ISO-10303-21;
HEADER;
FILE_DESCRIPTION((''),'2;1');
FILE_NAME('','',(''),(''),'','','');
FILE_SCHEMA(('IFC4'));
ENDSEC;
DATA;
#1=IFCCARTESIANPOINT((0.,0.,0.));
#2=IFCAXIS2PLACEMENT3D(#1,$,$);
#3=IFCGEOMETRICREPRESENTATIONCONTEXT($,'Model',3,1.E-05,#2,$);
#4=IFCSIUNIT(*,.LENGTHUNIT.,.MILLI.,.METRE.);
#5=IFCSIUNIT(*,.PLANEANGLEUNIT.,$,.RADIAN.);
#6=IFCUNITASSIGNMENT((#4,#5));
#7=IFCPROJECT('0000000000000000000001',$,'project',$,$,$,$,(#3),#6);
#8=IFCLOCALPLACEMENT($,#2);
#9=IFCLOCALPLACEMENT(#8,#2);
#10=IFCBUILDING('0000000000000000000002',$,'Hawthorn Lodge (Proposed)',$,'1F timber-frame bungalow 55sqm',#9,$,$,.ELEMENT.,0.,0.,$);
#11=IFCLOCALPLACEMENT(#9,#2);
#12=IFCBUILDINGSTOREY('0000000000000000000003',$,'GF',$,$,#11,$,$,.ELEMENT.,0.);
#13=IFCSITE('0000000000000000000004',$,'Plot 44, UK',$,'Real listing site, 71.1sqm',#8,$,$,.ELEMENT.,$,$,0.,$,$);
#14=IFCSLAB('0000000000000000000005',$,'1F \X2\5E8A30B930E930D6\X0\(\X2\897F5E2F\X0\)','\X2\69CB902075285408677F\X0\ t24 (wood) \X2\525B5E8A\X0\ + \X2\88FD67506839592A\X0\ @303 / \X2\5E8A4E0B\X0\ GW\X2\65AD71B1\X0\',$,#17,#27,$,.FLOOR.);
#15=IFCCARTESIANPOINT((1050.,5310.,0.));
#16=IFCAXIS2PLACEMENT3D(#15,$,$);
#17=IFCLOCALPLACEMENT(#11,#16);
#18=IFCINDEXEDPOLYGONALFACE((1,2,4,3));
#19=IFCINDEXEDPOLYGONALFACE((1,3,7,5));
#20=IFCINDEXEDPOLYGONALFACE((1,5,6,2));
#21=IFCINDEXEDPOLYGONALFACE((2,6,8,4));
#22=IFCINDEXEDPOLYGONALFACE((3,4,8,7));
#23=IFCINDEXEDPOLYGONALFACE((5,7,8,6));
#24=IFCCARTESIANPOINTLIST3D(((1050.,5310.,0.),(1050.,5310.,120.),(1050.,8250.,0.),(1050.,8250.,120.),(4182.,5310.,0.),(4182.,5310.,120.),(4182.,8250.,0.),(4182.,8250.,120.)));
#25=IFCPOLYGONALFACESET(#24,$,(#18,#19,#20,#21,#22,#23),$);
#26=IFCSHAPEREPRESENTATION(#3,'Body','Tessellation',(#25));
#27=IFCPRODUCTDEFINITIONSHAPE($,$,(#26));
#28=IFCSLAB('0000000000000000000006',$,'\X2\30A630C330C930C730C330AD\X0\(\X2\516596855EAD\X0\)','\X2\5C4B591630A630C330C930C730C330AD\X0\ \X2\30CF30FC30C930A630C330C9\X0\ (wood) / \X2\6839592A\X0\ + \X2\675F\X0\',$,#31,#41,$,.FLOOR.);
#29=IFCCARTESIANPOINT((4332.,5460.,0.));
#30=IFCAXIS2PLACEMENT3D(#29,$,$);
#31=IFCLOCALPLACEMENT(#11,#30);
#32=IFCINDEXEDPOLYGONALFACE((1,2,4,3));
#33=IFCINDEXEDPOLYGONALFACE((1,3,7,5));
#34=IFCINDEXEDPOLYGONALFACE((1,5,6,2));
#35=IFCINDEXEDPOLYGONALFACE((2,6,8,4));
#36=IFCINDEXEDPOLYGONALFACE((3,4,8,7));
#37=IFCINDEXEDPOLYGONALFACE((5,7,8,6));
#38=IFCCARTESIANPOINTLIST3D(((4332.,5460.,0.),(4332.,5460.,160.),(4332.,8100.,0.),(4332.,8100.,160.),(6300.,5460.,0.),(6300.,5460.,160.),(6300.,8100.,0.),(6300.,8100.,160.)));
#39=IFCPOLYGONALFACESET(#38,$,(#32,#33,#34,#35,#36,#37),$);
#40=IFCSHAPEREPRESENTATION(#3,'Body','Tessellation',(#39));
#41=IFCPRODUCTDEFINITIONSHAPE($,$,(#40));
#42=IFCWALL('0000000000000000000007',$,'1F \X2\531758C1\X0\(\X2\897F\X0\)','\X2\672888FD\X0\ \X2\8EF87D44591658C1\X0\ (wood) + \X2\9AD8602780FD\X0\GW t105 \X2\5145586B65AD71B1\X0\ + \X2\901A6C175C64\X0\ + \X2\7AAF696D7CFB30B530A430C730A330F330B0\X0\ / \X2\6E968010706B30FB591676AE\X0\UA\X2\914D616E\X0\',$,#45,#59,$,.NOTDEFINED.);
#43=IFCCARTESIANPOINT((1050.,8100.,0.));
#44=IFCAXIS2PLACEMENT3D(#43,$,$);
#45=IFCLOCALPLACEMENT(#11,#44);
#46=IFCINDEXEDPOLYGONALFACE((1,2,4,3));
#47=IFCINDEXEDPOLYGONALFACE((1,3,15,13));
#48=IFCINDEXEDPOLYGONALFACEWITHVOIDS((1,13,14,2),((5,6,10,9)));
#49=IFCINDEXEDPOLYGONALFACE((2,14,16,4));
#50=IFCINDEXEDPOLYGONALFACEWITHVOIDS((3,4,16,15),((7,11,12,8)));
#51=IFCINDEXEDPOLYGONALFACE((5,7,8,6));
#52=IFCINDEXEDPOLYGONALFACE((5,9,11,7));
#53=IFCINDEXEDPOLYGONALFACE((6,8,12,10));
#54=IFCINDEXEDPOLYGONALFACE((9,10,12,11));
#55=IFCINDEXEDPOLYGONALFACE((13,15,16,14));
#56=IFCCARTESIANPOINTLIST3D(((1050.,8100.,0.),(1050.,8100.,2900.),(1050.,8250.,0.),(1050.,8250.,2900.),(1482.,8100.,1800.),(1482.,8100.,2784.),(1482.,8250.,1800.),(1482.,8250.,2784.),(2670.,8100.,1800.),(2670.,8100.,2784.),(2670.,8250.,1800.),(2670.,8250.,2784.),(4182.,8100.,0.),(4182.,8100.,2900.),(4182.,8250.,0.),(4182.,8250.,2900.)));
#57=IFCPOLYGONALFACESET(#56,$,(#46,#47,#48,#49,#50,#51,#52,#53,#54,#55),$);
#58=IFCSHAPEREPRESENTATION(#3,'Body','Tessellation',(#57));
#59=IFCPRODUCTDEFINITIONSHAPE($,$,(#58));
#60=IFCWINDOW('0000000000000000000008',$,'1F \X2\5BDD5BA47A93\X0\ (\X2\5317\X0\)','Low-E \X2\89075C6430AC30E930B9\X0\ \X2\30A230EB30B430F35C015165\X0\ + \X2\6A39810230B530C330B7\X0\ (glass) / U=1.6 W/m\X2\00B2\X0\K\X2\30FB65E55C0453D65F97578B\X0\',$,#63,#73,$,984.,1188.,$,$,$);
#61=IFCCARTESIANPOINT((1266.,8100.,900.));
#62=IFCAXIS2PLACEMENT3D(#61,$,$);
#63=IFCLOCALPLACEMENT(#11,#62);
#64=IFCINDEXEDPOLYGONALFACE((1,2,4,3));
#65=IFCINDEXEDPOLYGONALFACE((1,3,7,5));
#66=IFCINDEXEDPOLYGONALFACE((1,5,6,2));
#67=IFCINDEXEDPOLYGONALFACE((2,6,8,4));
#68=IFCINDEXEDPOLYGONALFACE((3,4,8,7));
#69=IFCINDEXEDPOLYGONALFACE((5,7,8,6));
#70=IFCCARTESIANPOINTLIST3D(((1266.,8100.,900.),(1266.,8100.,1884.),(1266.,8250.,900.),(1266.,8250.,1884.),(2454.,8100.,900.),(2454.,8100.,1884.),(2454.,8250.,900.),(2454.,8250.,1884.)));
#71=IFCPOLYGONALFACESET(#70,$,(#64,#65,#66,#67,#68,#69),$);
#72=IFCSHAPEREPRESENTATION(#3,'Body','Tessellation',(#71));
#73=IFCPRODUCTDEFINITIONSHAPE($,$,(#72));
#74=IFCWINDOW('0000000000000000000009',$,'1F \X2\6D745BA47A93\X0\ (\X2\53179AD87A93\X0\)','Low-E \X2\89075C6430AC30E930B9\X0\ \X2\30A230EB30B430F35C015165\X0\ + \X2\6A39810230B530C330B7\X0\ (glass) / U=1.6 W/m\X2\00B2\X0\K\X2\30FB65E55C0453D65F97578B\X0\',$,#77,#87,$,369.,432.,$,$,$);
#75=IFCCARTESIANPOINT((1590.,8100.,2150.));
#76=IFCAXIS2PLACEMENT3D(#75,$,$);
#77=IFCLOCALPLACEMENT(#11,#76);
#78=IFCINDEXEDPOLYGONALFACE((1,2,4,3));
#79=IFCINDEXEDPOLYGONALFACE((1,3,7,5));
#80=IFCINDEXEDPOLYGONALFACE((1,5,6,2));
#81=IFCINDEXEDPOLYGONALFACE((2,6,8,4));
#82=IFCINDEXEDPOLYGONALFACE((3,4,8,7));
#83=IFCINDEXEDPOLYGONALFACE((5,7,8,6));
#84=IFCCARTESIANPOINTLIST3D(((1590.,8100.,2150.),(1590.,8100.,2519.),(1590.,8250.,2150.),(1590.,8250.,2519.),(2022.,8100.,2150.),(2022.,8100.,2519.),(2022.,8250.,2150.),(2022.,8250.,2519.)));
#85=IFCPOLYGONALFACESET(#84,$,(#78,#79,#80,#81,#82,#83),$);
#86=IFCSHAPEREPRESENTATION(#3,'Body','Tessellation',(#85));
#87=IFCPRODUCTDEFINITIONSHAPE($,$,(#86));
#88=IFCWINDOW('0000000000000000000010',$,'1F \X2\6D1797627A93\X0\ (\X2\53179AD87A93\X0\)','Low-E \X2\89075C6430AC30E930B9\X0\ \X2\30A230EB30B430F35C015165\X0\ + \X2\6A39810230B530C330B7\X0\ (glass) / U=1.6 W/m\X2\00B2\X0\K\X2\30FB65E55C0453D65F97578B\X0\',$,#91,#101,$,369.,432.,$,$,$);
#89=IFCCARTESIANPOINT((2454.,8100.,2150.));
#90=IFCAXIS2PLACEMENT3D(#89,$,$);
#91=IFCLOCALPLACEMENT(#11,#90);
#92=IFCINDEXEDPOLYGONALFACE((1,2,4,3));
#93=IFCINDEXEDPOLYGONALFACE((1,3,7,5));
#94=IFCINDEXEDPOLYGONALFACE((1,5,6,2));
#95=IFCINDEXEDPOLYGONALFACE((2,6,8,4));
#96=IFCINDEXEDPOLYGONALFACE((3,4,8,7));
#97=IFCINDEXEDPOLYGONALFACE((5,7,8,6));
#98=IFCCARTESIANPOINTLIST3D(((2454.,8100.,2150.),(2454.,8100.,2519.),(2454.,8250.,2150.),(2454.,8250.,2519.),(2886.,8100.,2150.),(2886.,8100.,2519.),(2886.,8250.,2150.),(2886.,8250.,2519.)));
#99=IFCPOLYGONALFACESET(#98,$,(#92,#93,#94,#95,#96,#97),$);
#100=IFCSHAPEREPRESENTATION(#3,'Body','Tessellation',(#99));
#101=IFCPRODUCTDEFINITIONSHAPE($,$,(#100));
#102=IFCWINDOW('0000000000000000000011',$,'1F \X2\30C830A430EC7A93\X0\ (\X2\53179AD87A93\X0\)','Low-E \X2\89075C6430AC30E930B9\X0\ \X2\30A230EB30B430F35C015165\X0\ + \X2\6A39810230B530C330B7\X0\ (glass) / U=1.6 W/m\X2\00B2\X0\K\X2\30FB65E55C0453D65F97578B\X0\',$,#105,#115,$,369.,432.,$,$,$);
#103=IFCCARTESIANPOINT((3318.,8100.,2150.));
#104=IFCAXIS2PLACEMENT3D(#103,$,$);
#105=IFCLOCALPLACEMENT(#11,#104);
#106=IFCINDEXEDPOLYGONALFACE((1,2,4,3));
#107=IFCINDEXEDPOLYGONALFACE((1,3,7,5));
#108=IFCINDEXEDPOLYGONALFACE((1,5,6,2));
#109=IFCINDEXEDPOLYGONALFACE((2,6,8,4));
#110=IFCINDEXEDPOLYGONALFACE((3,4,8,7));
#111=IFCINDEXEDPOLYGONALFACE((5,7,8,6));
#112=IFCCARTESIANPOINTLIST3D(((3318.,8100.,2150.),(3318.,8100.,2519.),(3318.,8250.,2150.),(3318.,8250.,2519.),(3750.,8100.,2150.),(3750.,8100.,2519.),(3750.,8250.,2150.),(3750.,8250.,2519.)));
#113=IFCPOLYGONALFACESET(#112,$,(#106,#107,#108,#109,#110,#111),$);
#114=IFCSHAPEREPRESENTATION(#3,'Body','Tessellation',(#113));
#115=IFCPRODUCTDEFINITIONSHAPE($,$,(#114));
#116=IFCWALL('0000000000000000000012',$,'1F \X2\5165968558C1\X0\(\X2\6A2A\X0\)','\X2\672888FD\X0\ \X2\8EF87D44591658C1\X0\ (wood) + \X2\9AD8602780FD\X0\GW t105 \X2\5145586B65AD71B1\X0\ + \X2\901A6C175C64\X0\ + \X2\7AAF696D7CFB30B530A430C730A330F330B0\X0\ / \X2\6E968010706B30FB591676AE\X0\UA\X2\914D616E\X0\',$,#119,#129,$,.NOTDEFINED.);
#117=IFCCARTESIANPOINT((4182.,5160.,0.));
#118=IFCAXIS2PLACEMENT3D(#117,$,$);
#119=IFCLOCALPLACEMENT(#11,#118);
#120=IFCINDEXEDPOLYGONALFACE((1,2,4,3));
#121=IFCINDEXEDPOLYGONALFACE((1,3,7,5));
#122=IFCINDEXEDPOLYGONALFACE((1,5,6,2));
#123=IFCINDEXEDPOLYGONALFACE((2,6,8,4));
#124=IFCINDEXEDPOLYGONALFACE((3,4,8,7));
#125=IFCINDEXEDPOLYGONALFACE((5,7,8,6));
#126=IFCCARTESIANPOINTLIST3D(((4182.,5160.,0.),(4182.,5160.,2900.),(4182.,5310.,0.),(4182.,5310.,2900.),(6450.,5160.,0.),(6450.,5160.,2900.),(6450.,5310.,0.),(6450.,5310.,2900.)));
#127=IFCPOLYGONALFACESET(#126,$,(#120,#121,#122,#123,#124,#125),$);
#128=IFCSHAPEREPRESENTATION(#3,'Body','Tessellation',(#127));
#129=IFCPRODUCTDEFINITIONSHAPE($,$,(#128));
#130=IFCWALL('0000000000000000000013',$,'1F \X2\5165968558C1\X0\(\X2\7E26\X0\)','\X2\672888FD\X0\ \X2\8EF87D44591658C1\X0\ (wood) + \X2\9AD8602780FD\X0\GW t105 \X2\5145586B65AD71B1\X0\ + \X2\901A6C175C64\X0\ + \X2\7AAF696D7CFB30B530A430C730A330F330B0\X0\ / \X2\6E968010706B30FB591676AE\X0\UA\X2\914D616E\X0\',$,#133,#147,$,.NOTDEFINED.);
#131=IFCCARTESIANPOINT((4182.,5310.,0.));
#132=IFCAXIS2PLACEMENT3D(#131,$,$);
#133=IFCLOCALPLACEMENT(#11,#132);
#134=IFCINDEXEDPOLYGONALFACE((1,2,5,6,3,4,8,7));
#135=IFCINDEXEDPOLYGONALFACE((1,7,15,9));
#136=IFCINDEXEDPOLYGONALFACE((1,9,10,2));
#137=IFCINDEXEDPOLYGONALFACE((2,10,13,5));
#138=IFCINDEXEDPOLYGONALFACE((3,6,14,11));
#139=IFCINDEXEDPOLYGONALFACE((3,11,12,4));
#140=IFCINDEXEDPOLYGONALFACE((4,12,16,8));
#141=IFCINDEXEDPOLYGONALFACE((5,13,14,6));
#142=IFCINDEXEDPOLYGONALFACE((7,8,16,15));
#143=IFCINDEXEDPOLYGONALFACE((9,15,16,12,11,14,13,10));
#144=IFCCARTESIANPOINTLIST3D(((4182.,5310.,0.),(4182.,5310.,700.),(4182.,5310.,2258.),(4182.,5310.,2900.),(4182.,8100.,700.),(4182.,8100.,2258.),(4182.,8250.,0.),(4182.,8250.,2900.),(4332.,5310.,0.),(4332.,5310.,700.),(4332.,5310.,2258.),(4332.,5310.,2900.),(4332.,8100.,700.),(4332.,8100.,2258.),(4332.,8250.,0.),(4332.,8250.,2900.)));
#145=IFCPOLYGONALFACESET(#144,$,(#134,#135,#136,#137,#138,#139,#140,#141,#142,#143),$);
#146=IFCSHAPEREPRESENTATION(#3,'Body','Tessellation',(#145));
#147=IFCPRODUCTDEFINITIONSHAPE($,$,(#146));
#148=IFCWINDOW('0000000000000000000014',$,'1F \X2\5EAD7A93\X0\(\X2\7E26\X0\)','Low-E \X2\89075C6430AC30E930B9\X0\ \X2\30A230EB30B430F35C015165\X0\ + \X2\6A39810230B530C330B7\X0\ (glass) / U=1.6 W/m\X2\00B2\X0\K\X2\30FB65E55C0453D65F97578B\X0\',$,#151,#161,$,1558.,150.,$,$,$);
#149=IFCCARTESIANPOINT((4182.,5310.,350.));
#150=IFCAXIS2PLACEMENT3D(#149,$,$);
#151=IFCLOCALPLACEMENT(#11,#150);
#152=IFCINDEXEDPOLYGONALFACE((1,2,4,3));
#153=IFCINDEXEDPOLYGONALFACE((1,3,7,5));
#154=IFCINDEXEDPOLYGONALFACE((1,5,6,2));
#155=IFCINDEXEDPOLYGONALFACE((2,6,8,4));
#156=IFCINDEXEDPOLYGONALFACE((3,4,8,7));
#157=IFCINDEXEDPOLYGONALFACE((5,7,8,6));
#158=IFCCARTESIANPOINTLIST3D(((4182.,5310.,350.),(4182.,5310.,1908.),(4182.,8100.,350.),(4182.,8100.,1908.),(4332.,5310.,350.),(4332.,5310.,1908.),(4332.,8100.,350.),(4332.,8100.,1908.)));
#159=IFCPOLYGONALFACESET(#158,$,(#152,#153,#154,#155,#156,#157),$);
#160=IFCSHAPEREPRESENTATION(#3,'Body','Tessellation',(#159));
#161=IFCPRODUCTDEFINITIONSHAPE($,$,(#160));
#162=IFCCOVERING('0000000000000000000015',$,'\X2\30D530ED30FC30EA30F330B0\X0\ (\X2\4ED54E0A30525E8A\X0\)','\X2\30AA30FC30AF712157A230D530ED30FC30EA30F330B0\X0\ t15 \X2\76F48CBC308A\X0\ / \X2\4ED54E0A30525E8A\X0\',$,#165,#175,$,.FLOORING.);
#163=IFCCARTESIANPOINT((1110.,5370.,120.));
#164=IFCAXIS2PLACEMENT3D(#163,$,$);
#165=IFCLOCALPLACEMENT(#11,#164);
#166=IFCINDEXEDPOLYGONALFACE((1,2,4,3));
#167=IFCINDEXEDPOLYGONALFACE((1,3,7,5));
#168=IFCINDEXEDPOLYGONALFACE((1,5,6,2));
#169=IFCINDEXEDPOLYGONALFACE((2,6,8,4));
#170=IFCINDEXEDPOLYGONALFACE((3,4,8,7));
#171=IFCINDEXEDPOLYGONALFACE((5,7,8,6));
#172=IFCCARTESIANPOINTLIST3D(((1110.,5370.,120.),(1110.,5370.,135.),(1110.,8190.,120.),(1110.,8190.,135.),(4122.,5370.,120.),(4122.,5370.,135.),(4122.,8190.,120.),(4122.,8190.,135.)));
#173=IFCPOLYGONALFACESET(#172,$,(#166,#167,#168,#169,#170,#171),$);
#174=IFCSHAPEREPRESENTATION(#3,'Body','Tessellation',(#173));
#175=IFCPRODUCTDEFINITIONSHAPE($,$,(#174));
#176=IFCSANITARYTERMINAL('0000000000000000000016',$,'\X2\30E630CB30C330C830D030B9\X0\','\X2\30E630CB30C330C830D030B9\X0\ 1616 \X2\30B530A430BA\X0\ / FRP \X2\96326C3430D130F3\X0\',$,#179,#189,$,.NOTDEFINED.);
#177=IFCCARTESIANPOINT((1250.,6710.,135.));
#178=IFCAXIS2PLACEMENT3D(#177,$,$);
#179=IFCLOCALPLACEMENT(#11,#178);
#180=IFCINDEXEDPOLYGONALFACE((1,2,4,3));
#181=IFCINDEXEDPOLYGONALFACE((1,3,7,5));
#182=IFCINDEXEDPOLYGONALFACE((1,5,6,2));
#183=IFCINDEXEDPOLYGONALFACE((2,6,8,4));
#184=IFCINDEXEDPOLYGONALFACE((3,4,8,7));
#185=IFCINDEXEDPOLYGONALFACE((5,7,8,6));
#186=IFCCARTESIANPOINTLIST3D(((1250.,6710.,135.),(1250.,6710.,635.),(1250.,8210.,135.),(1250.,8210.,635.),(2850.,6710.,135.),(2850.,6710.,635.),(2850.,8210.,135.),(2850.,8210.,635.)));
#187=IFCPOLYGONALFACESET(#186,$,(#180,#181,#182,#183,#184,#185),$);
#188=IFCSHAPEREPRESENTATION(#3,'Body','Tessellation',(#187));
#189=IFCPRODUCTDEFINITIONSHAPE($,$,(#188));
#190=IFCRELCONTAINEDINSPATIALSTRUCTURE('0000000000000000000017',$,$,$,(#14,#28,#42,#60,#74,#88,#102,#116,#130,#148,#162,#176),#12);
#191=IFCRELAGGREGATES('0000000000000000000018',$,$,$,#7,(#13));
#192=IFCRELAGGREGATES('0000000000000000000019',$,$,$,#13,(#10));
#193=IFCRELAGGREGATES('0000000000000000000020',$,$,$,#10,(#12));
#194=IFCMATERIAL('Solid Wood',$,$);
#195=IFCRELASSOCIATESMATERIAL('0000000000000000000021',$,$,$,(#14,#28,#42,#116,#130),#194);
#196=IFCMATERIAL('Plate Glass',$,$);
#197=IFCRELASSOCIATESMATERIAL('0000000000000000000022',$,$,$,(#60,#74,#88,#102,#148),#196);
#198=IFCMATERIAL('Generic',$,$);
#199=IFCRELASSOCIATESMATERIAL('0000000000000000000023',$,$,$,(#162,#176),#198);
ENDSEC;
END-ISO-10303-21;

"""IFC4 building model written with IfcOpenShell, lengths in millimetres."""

from ifc_helpers import new_model, si_unit, frame, frame_2d, origin, place, context, project, spatial, rectangle, extrude, material, element, fill, save


model = new_model("IFC4")

# Units and contexts
model_context = context("Model", 3, precision=1e-05, world=origin())
ifc_project = project(units=[si_unit("LENGTHUNIT", "METRE", prefix="MILLI"), si_unit("PLANEANGLEUNIT", "RADIAN")], contexts=[model_context])

# Site, building, storey
site_placement = place(None, origin())
site = spatial("IfcSite", under=ifc_project, at=site_placement, Name="Plot 44, UK", ObjectType="Real listing site, 71.1sqm", CompositionType="ELEMENT", RefElevation=0.0)
building_placement = place(site_placement, origin())
building = spatial("IfcBuilding", under=site, at=building_placement, Name="Hawthorn Lodge (Proposed)", ObjectType="1F timber-frame bungalow 55sqm", CompositionType="ELEMENT", ElevationOfRefHeight=0.0, ElevationOfTerrain=0.0)
storey_placement = place(building_placement, origin())
storey = spatial("IfcBuildingStorey", under=building, at=storey_placement, Name="GF", CompositionType="ELEMENT", Elevation=0.0)

# Slabs
ifc_material_1 = material(Name="Solid Wood")
slab_1_placement = place(storey_placement, frame((1050.0, 5310.0, 0.0)))
element("IfcSlab", 1, at=slab_1_placement, inside=storey, material=ifc_material_1, Name="1F 床スラブ(西帯)", Description="構造用合板 t24 (wood) 剛床 + 製材根太 @303 / 床下 GW断熱", PredefinedType="FLOOR", context=model_context, shape_type="SweptSolid", body=[
    extrude(rectangle(XDim=3132.0, YDim=2940.0, at=frame_2d((1566.0, 1470.0))), frame((1050.0, 5310.0, 0.0)), (0.0, 0.0, 1.0), 120.0),
])
slab_2_placement = place(storey_placement, frame((4332.0, 5460.0, 0.0)))
element("IfcSlab", 2, at=slab_2_placement, inside=storey, material=ifc_material_1, Name="ウッドデッキ(入隅庭)", Description="屋外ウッドデッキ ハードウッド (wood) / 根太 + 束", PredefinedType="FLOOR", context=model_context, shape_type="SweptSolid", body=[
    extrude(rectangle(XDim=1968.0, YDim=2640.0, at=frame_2d((984.0, 1320.0))), frame((4332.0, 5460.0, 0.0)), (0.0, 0.0, 1.0), 160.0),
])

# Wall, openings, windows
wall_1_placement = place(storey_placement, frame((1050.0, 8100.0, 0.0)))
wall_1 = element("IfcWall", 3, at=wall_1_placement, inside=storey, material=ifc_material_1, Name="1F 北壁(西)", Description="木製 軸組外壁 (wood) + 高性能GW t105 充填断熱 + 通気層 + 窯業系サイディング / 準耐火・外皮UA配慮", PredefinedType="NOTDEFINED", context=model_context, shape_type="SweptSolid", body=[
    extrude(rectangle(XDim=3132.0, YDim=150.0, at=frame_2d((1566.0, 75.0))), frame((1050.0, 8100.0, 0.0)), (0.0, 0.0, 1.0), 2900.0),
])
opening_1_placement = place(storey_placement, frame((1266.0, 8100.0, 900.0)))
opening_1 = element("IfcOpeningElement", 4, at=opening_1_placement, cuts=wall_1, PredefinedType="NOTDEFINED", context=model_context, shape_type="SweptSolid", body=[
    extrude(rectangle(XDim=1188.0, YDim=150.0, at=frame_2d((594.0, 75.0))), frame((1266.0, 8100.0, 900.0)), (0.0, 0.0, 1.0), 984.0),
])
opening_2_placement = place(storey_placement, frame((1590.0, 8100.0, 2150.0)))
opening_2 = element("IfcOpeningElement", 5, at=opening_2_placement, cuts=wall_1, PredefinedType="NOTDEFINED", context=model_context, shape_type="SweptSolid", body=[
    extrude(rectangle(XDim=432.0, YDim=150.0, at=frame_2d((216.0, 75.0))), frame((1590.0, 8100.0, 2150.0)), (0.0, 0.0, 1.0), 369.0),
])
opening_3_placement = place(storey_placement, frame((2454.0, 8100.0, 2150.0)))
opening_3 = element("IfcOpeningElement", 6, at=opening_3_placement, cuts=wall_1, PredefinedType="NOTDEFINED", context=model_context, shape_type="SweptSolid", body=[
    extrude(rectangle(XDim=432.0, YDim=150.0, at=frame_2d((216.0, 75.0))), frame((2454.0, 8100.0, 2150.0)), (0.0, 0.0, 1.0), 369.0),
])
opening_4_placement = place(storey_placement, frame((3318.0, 8100.0, 2150.0)))
opening_4 = element("IfcOpeningElement", 7, at=opening_4_placement, cuts=wall_1, PredefinedType="NOTDEFINED", context=model_context, shape_type="SweptSolid", body=[
    extrude(rectangle(XDim=432.0, YDim=150.0, at=frame_2d((216.0, 75.0))), frame((3318.0, 8100.0, 2150.0)), (0.0, 0.0, 1.0), 369.0),
])
ifc_material_2 = material(Name="Plate Glass")
window_1_placement = place(storey_placement, frame((1266.0, 8100.0, 900.0)))
window_1 = element("IfcWindow", 8, at=window_1_placement, inside=storey, material=ifc_material_2, Name="1F 寝室窓 (北)", Description="Low-E 複層ガラス アルゴン封入 + 樹脂サッシ (glass) / U=1.6 W/m²K・日射取得型", OverallHeight=984.0, OverallWidth=1188.0, context=model_context, shape_type="SweptSolid", body=[
    extrude(rectangle(XDim=1188.0, YDim=150.0, at=frame_2d((594.0, 75.0))), frame((1266.0, 8100.0, 900.0)), (0.0, 0.0, 1.0), 984.0),
])
fill(opening_1, window_1)
window_2_placement = place(storey_placement, frame((1590.0, 8100.0, 2150.0)))
window_2 = element("IfcWindow", 9, at=window_2_placement, inside=storey, material=ifc_material_2, Name="1F 浴室窓 (北高窓)", Description="Low-E 複層ガラス アルゴン封入 + 樹脂サッシ (glass) / U=1.6 W/m²K・日射取得型", OverallHeight=369.0, OverallWidth=432.0, context=model_context, shape_type="SweptSolid", body=[
    extrude(rectangle(XDim=432.0, YDim=150.0, at=frame_2d((216.0, 75.0))), frame((1590.0, 8100.0, 2150.0)), (0.0, 0.0, 1.0), 369.0),
])
fill(opening_2, window_2)
window_3_placement = place(storey_placement, frame((2454.0, 8100.0, 2150.0)))
window_3 = element("IfcWindow", 10, at=window_3_placement, inside=storey, material=ifc_material_2, Name="1F 洗面窓 (北高窓)", Description="Low-E 複層ガラス アルゴン封入 + 樹脂サッシ (glass) / U=1.6 W/m²K・日射取得型", OverallHeight=369.0, OverallWidth=432.0, context=model_context, shape_type="SweptSolid", body=[
    extrude(rectangle(XDim=432.0, YDim=150.0, at=frame_2d((216.0, 75.0))), frame((2454.0, 8100.0, 2150.0)), (0.0, 0.0, 1.0), 369.0),
])
fill(opening_3, window_3)
window_4_placement = place(storey_placement, frame((3318.0, 8100.0, 2150.0)))
window_4 = element("IfcWindow", 11, at=window_4_placement, inside=storey, material=ifc_material_2, Name="1F トイレ窓 (北高窓)", Description="Low-E 複層ガラス アルゴン封入 + 樹脂サッシ (glass) / U=1.6 W/m²K・日射取得型", OverallHeight=369.0, OverallWidth=432.0, context=model_context, shape_type="SweptSolid", body=[
    extrude(rectangle(XDim=432.0, YDim=150.0, at=frame_2d((216.0, 75.0))), frame((3318.0, 8100.0, 2150.0)), (0.0, 0.0, 1.0), 369.0),
])
fill(opening_4, window_4)

# Wall
wall_2_placement = place(storey_placement, frame((4182.0, 5160.0, 0.0)))
element("IfcWall", 12, at=wall_2_placement, inside=storey, material=ifc_material_1, Name="1F 入隅壁(横)", Description="木製 軸組外壁 (wood) + 高性能GW t105 充填断熱 + 通気層 + 窯業系サイディング / 準耐火・外皮UA配慮", PredefinedType="NOTDEFINED", context=model_context, shape_type="SweptSolid", body=[
    extrude(rectangle(XDim=2268.0, YDim=150.0, at=frame_2d((1134.0, 75.0))), frame((4182.0, 5160.0, 0.0)), (0.0, 0.0, 1.0), 2900.0),
])

# Wall, opening, window
wall_3_placement = place(storey_placement, frame((4182.0, 5310.0, 0.0)))
wall_3 = element("IfcWall", 13, at=wall_3_placement, inside=storey, material=ifc_material_1, Name="1F 入隅壁(縦)", Description="木製 軸組外壁 (wood) + 高性能GW t105 充填断熱 + 通気層 + 窯業系サイディング / 準耐火・外皮UA配慮", PredefinedType="NOTDEFINED", context=model_context, shape_type="SweptSolid", body=[
    extrude(rectangle(XDim=150.0, YDim=2940.0, at=frame_2d((75.0, 1470.0))), frame((4182.0, 5310.0, 0.0)), (0.0, 0.0, 1.0), 2900.0),
])
opening_5_placement = place(storey_placement, frame((4182.0, 5310.0, 350.0)))
opening_5 = element("IfcOpeningElement", 14, at=opening_5_placement, cuts=wall_3, PredefinedType="NOTDEFINED", context=model_context, shape_type="SweptSolid", body=[
    extrude(rectangle(XDim=150.0, YDim=2790.0, at=frame_2d((75.0, 1395.0))), frame((4182.0, 5310.0, 350.0)), (0.0, 0.0, 1.0), 1558.0),
])
window_5_placement = place(storey_placement, frame((4182.0, 5310.0, 350.0)))
window_5 = element("IfcWindow", 15, at=window_5_placement, inside=storey, material=ifc_material_2, Name="1F 庭窓(縦)", Description="Low-E 複層ガラス アルゴン封入 + 樹脂サッシ (glass) / U=1.6 W/m²K・日射取得型", OverallHeight=1558.0, OverallWidth=150.0, context=model_context, shape_type="SweptSolid", body=[
    extrude(rectangle(XDim=150.0, YDim=2790.0, at=frame_2d((75.0, 1395.0))), frame((4182.0, 5310.0, 350.0)), (0.0, 0.0, 1.0), 1558.0),
])
fill(opening_5, window_5)

# Covering
ifc_material_3 = material(Name="Generic")
covering_placement = place(storey_placement, frame((1110.0, 5370.0, 120.0)))
element("IfcCovering", 16, at=covering_placement, inside=storey, material=ifc_material_3, Name="フローリング (仕上げ床)", Description="オーク無垢フローリング t15 直貼り / 仕上げ床", PredefinedType="FLOORING", context=model_context, shape_type="SweptSolid", body=[
    extrude(rectangle(XDim=3012.0, YDim=2820.0, at=frame_2d((1506.0, 1410.0))), frame((1110.0, 5370.0, 120.0)), (0.0, 0.0, 1.0), 15.0),
])

# Sanitary terminal
sanitary_terminal_1_placement = place(storey_placement, frame((1250.0, 6710.0, 135.0)))
element("IfcSanitaryTerminal", 17, at=sanitary_terminal_1_placement, inside=storey, material=ifc_material_3, Name="ユニットバス", Description="ユニットバス 1616 サイズ / FRP 防水パン", PredefinedType="NOTDEFINED", context=model_context, shape_type="SweptSolid", body=[
    extrude(rectangle(XDim=1600.0, YDim=1500.0, at=frame_2d((800.0, 750.0))), frame((1250.0, 6710.0, 135.0)), (0.0, 0.0, 1.0), 500.0),
])

save(model, "model.ifc")
